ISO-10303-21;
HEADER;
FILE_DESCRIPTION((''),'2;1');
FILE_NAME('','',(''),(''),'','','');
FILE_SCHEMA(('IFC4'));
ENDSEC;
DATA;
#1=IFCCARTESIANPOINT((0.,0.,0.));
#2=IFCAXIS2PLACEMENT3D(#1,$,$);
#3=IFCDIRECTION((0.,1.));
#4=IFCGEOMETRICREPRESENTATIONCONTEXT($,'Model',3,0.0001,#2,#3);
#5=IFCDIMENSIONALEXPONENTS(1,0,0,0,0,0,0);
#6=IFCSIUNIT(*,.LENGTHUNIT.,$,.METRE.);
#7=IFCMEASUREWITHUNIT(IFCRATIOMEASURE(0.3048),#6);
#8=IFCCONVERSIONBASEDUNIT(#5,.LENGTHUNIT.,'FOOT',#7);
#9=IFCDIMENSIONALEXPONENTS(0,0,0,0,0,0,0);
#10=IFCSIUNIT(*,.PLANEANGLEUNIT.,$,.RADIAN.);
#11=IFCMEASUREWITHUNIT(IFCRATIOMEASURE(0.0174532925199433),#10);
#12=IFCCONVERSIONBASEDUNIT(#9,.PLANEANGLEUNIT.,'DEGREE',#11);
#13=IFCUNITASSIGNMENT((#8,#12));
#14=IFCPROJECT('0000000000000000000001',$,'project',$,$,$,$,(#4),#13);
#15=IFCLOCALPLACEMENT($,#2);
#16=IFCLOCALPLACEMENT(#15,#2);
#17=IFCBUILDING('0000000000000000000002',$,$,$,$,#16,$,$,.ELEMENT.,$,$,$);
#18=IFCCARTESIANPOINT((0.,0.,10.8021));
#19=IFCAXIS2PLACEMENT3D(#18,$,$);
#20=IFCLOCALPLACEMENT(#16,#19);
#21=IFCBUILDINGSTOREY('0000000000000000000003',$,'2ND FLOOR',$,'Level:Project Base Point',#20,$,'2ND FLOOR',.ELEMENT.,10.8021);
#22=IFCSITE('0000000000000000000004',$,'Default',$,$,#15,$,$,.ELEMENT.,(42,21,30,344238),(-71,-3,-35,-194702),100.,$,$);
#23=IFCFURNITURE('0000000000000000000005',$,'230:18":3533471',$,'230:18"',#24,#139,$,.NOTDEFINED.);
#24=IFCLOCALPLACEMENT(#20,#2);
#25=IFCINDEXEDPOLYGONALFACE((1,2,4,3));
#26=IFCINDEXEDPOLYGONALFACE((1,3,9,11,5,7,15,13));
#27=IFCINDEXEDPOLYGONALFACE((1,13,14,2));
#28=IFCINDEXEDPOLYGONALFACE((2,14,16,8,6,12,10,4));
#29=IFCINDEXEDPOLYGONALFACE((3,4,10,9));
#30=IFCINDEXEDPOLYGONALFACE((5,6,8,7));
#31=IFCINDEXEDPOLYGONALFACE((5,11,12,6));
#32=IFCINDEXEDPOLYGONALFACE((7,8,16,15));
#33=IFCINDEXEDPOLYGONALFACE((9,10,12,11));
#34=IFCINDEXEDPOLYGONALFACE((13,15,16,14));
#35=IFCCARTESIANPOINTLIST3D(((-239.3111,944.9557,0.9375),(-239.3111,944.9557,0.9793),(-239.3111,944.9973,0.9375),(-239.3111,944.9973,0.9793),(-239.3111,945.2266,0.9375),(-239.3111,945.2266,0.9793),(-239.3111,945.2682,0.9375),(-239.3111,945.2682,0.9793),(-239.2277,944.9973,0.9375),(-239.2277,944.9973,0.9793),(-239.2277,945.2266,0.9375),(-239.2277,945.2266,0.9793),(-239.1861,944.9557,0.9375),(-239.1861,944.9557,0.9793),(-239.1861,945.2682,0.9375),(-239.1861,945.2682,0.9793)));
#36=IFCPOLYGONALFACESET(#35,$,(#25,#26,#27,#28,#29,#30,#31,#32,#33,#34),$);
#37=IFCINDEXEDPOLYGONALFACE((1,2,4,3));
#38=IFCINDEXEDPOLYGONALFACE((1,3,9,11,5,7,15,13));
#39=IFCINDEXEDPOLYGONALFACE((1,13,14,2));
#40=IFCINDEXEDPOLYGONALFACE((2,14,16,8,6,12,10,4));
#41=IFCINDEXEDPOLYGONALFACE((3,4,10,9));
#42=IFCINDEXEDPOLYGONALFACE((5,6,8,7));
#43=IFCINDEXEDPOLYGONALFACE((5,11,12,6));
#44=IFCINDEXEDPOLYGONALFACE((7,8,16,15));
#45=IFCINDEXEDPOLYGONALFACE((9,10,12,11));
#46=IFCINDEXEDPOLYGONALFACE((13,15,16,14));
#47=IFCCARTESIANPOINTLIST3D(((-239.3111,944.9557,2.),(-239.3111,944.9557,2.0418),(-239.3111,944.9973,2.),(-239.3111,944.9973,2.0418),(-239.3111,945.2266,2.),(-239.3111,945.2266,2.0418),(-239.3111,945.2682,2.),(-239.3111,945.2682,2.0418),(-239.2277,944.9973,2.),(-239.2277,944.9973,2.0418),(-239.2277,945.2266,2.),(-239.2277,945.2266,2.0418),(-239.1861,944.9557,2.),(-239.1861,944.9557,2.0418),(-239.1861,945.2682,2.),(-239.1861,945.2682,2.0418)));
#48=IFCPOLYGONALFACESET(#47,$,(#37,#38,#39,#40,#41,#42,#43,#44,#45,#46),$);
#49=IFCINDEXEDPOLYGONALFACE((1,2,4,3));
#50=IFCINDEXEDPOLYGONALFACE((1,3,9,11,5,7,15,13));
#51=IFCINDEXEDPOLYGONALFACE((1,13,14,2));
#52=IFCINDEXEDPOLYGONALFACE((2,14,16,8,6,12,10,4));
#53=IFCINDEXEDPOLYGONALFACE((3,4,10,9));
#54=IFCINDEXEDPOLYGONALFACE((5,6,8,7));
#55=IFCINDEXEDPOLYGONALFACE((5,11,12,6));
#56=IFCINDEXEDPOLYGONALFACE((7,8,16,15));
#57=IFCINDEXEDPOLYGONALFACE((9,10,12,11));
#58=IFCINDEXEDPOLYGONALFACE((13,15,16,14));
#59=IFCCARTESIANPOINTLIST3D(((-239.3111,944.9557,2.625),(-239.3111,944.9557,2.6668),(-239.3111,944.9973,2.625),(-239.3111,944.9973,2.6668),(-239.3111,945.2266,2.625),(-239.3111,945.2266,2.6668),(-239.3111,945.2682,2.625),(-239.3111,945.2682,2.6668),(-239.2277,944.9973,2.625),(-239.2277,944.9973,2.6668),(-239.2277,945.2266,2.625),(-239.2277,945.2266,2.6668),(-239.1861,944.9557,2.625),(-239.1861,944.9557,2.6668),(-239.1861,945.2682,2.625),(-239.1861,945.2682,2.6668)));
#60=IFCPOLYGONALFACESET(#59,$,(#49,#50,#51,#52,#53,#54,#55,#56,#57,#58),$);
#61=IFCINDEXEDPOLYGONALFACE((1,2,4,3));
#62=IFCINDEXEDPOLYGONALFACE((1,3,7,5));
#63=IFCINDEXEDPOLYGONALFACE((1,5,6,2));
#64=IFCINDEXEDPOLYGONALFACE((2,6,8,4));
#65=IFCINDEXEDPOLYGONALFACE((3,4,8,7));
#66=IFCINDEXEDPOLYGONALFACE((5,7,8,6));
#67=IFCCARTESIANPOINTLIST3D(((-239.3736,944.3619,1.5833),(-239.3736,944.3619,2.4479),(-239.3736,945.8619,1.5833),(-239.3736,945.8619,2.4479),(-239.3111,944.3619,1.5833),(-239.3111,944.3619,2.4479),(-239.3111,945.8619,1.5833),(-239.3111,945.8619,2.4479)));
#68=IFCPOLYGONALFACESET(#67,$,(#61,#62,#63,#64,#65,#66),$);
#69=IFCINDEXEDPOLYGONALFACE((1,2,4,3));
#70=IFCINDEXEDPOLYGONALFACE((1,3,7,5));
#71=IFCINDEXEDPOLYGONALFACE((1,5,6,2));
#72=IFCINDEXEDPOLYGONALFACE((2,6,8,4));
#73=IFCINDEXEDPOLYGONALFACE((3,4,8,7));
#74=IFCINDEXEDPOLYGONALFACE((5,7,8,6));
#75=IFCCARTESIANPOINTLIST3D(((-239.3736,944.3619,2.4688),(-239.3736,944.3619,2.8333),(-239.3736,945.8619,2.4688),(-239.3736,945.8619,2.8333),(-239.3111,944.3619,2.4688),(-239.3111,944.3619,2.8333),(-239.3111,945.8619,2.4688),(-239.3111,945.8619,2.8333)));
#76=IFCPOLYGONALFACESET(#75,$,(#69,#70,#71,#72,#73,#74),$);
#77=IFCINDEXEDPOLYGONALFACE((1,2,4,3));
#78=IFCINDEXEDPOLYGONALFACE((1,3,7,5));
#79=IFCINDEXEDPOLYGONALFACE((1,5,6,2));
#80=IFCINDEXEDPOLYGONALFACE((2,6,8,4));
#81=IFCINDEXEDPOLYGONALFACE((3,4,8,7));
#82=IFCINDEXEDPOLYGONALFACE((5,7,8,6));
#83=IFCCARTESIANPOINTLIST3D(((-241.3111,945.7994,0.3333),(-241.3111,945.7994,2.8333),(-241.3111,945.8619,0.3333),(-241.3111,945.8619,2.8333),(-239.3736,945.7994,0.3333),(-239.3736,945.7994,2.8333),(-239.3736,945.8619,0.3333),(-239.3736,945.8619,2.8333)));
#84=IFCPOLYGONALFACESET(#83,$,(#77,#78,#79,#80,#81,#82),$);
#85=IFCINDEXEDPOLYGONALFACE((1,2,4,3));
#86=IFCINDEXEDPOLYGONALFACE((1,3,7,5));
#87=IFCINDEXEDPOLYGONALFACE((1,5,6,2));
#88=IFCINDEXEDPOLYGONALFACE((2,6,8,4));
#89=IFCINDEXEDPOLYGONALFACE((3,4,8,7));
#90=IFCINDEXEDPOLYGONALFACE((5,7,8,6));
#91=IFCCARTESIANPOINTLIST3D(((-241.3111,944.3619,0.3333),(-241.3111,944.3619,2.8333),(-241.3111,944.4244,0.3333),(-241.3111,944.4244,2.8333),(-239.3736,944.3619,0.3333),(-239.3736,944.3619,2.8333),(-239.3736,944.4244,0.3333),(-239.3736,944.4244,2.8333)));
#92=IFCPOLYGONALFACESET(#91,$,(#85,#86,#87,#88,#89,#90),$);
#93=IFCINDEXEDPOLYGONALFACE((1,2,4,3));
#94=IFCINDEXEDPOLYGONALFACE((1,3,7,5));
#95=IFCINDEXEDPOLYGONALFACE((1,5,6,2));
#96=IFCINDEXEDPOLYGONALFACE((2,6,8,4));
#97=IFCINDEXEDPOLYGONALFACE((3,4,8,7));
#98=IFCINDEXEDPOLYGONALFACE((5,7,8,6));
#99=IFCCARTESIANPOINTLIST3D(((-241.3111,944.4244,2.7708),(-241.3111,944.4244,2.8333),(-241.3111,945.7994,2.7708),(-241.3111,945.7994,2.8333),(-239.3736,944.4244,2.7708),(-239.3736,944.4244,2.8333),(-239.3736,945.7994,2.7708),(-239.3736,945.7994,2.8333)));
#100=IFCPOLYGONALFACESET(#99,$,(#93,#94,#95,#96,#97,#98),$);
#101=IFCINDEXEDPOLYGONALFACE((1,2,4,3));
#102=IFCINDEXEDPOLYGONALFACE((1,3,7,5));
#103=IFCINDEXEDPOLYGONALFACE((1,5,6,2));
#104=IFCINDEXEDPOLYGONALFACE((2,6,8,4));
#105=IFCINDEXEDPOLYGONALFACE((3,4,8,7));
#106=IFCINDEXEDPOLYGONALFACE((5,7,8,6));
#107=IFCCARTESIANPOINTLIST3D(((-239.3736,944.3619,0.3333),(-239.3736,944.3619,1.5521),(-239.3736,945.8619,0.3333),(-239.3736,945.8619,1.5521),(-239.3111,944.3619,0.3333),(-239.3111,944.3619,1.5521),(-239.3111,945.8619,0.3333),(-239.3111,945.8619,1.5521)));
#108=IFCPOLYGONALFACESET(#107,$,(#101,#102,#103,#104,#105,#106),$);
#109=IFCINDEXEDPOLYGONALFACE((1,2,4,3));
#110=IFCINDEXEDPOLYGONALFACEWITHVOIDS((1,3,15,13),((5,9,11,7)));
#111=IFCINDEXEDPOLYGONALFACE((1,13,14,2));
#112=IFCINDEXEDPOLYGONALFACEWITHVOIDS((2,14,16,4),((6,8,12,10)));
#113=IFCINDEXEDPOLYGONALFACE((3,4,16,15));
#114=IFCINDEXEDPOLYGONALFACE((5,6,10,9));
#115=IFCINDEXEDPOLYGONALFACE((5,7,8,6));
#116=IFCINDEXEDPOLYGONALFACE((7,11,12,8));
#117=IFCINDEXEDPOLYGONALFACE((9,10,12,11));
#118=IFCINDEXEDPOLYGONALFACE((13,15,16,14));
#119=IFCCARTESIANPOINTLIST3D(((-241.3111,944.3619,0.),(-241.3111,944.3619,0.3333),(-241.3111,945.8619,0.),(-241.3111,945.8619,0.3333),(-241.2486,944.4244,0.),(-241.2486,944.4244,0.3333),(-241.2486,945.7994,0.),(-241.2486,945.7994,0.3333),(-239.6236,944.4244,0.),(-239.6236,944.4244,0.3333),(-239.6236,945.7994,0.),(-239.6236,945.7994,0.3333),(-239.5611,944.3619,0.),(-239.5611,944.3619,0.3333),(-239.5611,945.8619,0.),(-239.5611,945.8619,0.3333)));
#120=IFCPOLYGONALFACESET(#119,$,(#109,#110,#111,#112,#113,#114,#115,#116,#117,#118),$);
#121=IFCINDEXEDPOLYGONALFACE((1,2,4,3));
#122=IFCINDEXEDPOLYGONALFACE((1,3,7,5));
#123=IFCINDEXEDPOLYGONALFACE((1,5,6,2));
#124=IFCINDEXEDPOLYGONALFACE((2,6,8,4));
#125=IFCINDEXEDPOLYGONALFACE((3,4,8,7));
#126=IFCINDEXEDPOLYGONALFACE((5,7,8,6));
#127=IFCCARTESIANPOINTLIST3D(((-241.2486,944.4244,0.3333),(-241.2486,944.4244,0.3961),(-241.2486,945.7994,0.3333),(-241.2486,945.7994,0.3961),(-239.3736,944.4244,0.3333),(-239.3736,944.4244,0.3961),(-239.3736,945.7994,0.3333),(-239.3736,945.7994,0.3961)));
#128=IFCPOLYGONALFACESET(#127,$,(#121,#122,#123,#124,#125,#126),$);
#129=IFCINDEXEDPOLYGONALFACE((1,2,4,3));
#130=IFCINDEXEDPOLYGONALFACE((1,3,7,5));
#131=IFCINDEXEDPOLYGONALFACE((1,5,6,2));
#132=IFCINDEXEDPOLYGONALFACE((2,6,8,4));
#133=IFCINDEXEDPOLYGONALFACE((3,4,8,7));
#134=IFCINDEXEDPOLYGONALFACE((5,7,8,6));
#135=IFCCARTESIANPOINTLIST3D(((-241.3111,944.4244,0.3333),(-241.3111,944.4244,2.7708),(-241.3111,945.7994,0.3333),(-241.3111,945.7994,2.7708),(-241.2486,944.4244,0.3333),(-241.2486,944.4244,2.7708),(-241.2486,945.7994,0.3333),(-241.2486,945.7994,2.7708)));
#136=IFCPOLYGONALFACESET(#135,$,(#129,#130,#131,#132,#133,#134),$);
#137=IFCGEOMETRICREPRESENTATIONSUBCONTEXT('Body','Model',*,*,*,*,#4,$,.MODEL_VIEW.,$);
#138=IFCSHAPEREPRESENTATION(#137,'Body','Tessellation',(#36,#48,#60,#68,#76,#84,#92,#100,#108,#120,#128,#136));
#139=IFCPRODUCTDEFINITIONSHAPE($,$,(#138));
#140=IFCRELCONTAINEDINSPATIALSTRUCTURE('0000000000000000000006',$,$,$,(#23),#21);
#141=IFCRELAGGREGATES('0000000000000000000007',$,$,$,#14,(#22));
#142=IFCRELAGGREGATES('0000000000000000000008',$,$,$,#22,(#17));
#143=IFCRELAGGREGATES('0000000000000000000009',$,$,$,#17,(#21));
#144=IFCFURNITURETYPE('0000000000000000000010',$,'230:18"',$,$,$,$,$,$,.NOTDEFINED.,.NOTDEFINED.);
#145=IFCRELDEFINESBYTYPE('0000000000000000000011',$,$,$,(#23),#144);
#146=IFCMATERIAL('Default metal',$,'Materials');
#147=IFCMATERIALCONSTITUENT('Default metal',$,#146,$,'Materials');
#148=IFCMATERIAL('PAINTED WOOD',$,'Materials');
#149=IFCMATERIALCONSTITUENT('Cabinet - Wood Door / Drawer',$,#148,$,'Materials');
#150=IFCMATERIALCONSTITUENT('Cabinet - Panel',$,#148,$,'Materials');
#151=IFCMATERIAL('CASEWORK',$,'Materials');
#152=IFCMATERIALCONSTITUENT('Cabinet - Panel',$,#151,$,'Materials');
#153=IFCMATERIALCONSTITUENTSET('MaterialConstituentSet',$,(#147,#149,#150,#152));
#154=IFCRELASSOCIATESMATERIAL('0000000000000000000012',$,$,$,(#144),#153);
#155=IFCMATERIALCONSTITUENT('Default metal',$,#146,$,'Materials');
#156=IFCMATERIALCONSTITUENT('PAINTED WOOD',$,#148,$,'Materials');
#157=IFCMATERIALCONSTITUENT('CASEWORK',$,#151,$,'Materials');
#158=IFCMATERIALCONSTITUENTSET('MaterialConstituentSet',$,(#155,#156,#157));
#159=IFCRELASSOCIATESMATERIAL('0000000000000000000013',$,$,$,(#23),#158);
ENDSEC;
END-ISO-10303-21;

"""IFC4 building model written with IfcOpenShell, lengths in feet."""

from ifc_helpers import new_model, entity, si_unit, converted_unit, direction, frame, frame_2d, origin, origin_2d_with_axis, place, context, subcontext, project, spatial, polyline, rectangle, outline, extrude, source, transform, mapped, material, constituent, constituent_set, type_object, type_shapes, element, save


model = new_model("IFC4")

# Units and contexts
model_context = context("Model", 3, precision=0.0001, world=origin(), true_north=direction((0.0, 1.0)))
body_context = subcontext(model_context, "Body", "Model", "MODEL_VIEW")
ifc_project = project(units=[converted_unit("LENGTHUNIT", "FOOT", entity("IfcRatioMeasure", 0.3048), si_unit("LENGTHUNIT", "METRE"), dimensions=[1, 0, 0, 0, 0, 0, 0]), converted_unit("PLANEANGLEUNIT", "DEGREE", entity("IfcRatioMeasure", 0.0174532925199433), si_unit("PLANEANGLEUNIT", "RADIAN"), dimensions=[0, 0, 0, 0, 0, 0, 0])], contexts=[model_context])

# Site, building, storey
site_placement = place(None, origin())
site = spatial("IfcSite", under=ifc_project, at=site_placement, Name="Default", CompositionType="ELEMENT", RefLatitude=(42, 21, 30, 344238), RefLongitude=(-71, -3, -35, -194702), RefElevation=100.0)
building_placement = place(site_placement, origin())
building = spatial("IfcBuilding", under=site, at=building_placement, CompositionType="ELEMENT")
storey_placement = place(building_placement, frame((0.0, 0.0, 10.8021)))
storey = spatial("IfcBuildingStorey", under=building, at=storey_placement, Name="2ND FLOOR", ObjectType="Level:Project Base Point", LongName="2ND FLOOR", CompositionType="ELEMENT", Elevation=10.8021)

# Shared definitions
ifc_material_1 = material(Name="Default metal", Category="Materials")
ifc_material_2 = material(Name="PAINTED WOOD", Category="Materials")
ifc_material_3 = material(Name="CASEWORK", Category="Materials")

# Furniture
ifc_constituent_1 = constituent(ifc_material_1, Name="Default metal", Category="Materials")
ifc_constituent_2 = constituent(ifc_material_2, Name="PAINTED WOOD", Category="Materials")
ifc_constituent_3 = constituent(ifc_material_3, Name="CASEWORK", Category="Materials")
ifc_constituent_set_1 = constituent_set(constituents=[ifc_constituent_1, ifc_constituent_2, ifc_constituent_3], Name="MaterialConstituentSet")
ifc_constituent_4 = constituent(ifc_material_1, Name="Default metal", Category="Materials")
ifc_constituent_5 = constituent(ifc_material_2, Name="Cabinet - Wood Door / Drawer", Category="Materials")
ifc_constituent_6 = constituent(ifc_material_2, Name="Cabinet - Panel", Category="Materials")
ifc_constituent_7 = constituent(ifc_material_3, Name="Cabinet - Panel", Category="Materials")
ifc_constituent_set_2 = constituent_set(constituents=[ifc_constituent_4, ifc_constituent_5, ifc_constituent_6, ifc_constituent_7], Name="MaterialConstituentSet")
furniture_type_1 = type_object("IfcFurnitureType", Name="230:18\"", AssemblyPlace="NOTDEFINED", PredefinedType="NOTDEFINED", material=ifc_constituent_set_2)
shared_shape_1 = source(origin(), body_context, "Body", "SweptSolid", [
    extrude(outline(polyline([(-0.1562, -0.0521), (-0.1146, -0.0521), (-0.1146, 0.0313), (0.1146, 0.0313), (0.1146, -0.0521), (0.1562, -0.0521), (0.1562, 0.0729), (-0.1562, 0.0729), (-0.1562, -0.0521)])), frame((0.0615, 2.0521, 0.9375)), (0.0, 0.0, 1.0), 0.0418),
    extrude(outline(polyline([(-0.1562, -0.0521), (-0.1146, -0.0521), (-0.1146, 0.0313), (0.1146, 0.0313), (0.1146, -0.0521), (0.1562, -0.0521), (0.1562, 0.0729), (-0.1562, 0.0729), (-0.1562, -0.0521)])), frame((0.0615, 2.0521, 2.0)), (0.0, 0.0, 1.0), 0.0418),
    extrude(outline(polyline([(-0.1562, -0.0521), (-0.1146, -0.0521), (-0.1146, 0.0313), (0.1146, 0.0313), (0.1146, -0.0521), (0.1562, -0.0521), (0.1562, 0.0729), (-0.1562, 0.0729), (-0.1562, -0.0521)])), frame((0.0615, 2.0521, 2.625)), (0.0, 0.0, 1.0), 0.0418),
    extrude(rectangle(XDim=1.5, YDim=0.0625, at=frame_2d((0.0, 0.0), x_axis=(1.0, 0.0))), frame((0.0615, 1.9688, 1.5833), z_axis=(0.0, 0.0, 1.0), x_axis=(-1.0, 0.0, 0.0)), (0.0, 0.0, 1.0), 0.8646),
    extrude(rectangle(XDim=1.5, YDim=0.0625, at=frame_2d((0.0, 0.0), x_axis=(1.0, 0.0))), frame((0.0615, 1.9688, 2.4688), z_axis=(0.0, 0.0, 1.0), x_axis=(-1.0, 0.0, 0.0)), (0.0, 0.0, 1.0), 0.3646),
    extrude(rectangle(XDim=1.9375, YDim=0.0625, at=frame_2d((0.0, 0.0), x_axis=(1.0, 0.0))), frame((-0.6573, 0.9687, 0.3333), z_axis=(0.0, 0.0, 1.0), x_axis=(0.0, -1.0, 0.0)), (0.0, 0.0, 1.0), 2.5),
    extrude(rectangle(XDim=1.9375, YDim=0.0625, at=frame_2d((0.0, 0.0), x_axis=(1.0, 0.0))), frame((0.7802, 0.9687, 0.3333), z_axis=(0.0, 0.0, 1.0), x_axis=(0.0, -1.0, 0.0)), (0.0, 0.0, 1.0), 2.5),
    extrude(rectangle(XDim=1.9375, YDim=1.375, at=origin_2d_with_axis()), frame((0.0615, 0.9687, 2.7708), z_axis=(0.0, 0.0, 1.0), x_axis=(0.0, 1.0, 0.0)), (0.0, 0.0, 1.0), 0.0625),
    extrude(rectangle(XDim=1.5, YDim=0.0625, at=frame_2d((0.0, 0.0), x_axis=(1.0, 0.0))), frame((0.0615, 1.9688, 0.3333), z_axis=(0.0, 0.0, 1.0), x_axis=(-1.0, 0.0, 0.0)), (0.0, 0.0, 1.0), 1.2187),
    extrude(outline(polyline([(-0.875, -0.75), (0.875, -0.75), (0.875, 0.75), (-0.875, 0.75), (-0.875, -0.75)]), holes=[polyline([(-0.8125, -0.6875), (-0.8125, 0.6875), (0.8125, 0.6875), (0.8125, -0.6875), (-0.8125, -0.6875)])]), frame((0.0615, 0.875, 0.0), z_axis=(0.0, 0.0, 1.0), x_axis=(0.0, -1.0, 0.0)), (0.0, 0.0, 1.0), 0.3333),
    extrude(rectangle(XDim=1.875, YDim=1.375, at=origin_2d_with_axis()), frame((0.0615, 1.0, 0.3333), z_axis=(0.0, 0.0, 1.0), x_axis=(0.0, 1.0, 0.0)), (0.0, 0.0, 1.0), 0.0627),
    extrude(rectangle(XDim=1.375, YDim=0.0625, at=origin_2d_with_axis()), frame((0.0615, 0.0312, 0.3333), z_axis=(0.0, 0.0, 1.0), x_axis=(-1.0, 0.0, 0.0)), (0.0, 0.0, 1.0), 2.4375),
])
type_shapes(furniture_type_1, [shared_shape_1])
furniture_1_placement = place(storey_placement, frame((-241.3111, 945.1734, 0.0), z_axis=(0.0, 0.0, 1.0), x_axis=(0.0, -1.0, 0.0)))
element("IfcFurniture", 1, at=furniture_1_placement, inside=storey, type_object=furniture_type_1, material=ifc_constituent_set_1, Name="230:18\":3533471", ObjectType="230:18\"", PredefinedType="NOTDEFINED", context=body_context, shape_type="MappedRepresentation", body=[
    mapped(shared_shape_1, transform((0.0, 0.0, 0.0), scale=1.0)),
])

save(model, "model.ifc")
